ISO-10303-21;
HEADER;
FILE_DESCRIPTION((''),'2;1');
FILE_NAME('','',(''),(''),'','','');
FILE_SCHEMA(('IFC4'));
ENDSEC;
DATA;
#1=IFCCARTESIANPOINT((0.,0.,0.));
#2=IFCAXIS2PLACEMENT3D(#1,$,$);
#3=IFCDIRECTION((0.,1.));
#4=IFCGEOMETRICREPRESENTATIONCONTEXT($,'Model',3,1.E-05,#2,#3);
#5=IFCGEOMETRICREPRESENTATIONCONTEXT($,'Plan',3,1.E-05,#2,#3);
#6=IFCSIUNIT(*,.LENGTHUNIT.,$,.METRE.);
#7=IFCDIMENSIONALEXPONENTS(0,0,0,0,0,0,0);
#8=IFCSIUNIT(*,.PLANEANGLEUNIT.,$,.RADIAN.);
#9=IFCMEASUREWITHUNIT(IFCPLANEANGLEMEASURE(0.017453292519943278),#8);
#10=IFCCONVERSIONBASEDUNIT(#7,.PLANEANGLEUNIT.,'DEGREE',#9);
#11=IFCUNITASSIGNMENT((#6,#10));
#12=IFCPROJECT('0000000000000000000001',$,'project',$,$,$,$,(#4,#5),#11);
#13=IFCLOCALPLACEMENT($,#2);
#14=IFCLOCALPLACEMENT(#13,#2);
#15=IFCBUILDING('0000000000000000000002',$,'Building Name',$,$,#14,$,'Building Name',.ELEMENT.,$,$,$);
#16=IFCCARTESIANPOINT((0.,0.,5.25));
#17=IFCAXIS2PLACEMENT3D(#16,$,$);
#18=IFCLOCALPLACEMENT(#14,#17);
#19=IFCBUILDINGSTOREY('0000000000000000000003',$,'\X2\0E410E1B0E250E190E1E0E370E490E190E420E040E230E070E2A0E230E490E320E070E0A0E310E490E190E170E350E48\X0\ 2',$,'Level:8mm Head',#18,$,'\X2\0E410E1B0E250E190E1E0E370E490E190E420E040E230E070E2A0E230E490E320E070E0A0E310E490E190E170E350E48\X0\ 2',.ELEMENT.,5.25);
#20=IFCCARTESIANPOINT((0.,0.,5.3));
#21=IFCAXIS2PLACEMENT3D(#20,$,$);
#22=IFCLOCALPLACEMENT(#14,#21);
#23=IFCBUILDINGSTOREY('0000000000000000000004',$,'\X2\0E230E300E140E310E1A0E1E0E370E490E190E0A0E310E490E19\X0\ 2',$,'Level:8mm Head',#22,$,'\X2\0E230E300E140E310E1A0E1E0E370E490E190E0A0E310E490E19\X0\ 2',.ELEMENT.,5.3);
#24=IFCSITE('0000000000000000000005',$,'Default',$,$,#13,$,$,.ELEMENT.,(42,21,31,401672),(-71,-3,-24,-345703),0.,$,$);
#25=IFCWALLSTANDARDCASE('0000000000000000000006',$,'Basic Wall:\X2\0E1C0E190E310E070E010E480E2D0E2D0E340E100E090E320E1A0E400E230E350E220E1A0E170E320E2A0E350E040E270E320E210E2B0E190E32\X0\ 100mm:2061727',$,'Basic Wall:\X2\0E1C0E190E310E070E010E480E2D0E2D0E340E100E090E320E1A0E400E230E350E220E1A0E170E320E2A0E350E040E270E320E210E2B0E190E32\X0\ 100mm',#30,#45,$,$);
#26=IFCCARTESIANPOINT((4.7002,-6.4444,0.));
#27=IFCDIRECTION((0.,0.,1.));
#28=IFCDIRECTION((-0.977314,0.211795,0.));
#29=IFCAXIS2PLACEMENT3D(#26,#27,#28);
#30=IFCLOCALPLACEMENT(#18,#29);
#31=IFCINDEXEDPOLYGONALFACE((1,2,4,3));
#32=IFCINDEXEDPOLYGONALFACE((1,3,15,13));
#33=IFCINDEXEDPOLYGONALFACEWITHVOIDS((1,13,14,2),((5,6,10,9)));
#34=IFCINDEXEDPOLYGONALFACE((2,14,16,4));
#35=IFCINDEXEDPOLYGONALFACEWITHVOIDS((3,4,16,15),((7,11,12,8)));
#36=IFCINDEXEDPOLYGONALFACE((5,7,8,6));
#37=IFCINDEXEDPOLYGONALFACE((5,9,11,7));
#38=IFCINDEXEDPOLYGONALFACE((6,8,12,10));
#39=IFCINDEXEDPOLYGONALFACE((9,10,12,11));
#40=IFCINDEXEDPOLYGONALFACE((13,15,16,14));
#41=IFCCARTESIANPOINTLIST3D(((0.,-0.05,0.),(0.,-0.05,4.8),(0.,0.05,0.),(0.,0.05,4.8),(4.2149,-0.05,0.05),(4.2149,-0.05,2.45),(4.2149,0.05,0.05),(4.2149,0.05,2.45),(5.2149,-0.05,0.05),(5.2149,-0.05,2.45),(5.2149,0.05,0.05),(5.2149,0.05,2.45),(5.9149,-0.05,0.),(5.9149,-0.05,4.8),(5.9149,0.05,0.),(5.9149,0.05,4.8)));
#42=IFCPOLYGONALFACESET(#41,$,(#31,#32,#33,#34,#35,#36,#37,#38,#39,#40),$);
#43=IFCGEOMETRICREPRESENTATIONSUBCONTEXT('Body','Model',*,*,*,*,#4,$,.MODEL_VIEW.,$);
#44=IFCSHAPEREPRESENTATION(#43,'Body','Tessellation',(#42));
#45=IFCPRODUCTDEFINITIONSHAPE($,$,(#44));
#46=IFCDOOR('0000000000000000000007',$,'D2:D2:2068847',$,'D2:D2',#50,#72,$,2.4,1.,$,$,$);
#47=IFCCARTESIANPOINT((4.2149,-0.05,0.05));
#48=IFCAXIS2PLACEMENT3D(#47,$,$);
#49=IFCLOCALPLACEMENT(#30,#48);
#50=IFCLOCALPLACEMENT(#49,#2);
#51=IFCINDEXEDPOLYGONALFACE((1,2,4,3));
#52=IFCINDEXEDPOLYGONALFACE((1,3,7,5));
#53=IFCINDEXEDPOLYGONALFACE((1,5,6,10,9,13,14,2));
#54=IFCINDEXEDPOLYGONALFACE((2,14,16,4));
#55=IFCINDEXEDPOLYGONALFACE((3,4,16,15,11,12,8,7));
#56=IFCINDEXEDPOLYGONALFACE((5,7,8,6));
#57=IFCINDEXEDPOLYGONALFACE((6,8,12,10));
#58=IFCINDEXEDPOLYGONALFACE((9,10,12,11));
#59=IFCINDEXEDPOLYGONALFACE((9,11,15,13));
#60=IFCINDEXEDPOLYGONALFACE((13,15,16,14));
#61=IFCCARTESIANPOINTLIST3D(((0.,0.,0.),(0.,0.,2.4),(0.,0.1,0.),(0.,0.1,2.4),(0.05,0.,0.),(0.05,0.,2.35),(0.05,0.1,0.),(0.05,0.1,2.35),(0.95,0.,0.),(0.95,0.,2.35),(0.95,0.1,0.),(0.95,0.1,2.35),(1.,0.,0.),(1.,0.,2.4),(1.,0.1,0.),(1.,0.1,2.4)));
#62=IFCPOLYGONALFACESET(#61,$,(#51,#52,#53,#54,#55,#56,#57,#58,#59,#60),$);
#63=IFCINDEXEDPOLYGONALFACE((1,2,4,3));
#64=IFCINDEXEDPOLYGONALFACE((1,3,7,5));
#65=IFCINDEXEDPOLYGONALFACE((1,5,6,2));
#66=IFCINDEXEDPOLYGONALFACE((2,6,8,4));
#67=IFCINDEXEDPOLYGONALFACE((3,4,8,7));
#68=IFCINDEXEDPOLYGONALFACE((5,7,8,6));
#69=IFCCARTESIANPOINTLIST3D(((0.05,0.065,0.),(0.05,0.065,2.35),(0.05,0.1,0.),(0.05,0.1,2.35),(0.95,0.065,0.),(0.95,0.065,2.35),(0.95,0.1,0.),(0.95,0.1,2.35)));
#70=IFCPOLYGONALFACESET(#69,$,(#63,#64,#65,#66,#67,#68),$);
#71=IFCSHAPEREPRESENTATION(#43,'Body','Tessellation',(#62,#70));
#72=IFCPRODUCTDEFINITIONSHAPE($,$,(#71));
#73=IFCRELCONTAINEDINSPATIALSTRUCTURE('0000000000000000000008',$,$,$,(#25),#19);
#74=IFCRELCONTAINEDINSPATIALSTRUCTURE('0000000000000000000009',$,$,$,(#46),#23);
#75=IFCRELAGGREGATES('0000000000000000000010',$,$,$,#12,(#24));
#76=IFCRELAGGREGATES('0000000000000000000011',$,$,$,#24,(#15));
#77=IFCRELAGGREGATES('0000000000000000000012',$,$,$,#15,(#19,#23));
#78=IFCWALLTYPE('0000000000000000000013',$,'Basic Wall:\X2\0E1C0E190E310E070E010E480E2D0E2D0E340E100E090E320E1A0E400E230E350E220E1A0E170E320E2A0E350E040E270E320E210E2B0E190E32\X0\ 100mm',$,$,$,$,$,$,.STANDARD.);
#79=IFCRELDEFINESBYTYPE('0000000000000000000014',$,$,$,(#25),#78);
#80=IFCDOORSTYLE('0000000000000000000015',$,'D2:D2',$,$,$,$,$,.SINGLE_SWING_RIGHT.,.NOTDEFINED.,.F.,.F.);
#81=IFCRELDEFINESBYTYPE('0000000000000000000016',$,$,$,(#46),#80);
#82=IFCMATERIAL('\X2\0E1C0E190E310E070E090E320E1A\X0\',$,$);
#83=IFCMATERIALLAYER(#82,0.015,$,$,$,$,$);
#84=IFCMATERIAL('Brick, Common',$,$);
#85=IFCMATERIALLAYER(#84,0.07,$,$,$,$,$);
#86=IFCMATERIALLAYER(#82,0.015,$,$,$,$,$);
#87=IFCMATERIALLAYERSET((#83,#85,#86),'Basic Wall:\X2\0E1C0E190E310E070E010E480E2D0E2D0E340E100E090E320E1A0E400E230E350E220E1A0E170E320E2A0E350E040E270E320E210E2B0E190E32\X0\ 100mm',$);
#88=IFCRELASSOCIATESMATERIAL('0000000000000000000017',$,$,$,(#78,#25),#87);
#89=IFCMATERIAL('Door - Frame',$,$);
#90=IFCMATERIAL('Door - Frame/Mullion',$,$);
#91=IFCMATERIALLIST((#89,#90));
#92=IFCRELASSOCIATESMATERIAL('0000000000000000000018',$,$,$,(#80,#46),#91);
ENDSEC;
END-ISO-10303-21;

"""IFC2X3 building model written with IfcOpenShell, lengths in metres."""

from ifc_helpers import new_model, entity, si_unit, converted_unit, direction, frame, frame_2d, origin, origin_2d_with_axis, place, context, subcontext, project, spatial, polyline, rectangle, outline, extrude, source, transform, mapped, material, material_list, layer, layer_set, layer_usage, type_object, type_shapes, element, fill, save


model = new_model("IFC2X3")

# Units and contexts
model_context = context("Model", 3, precision=1e-05, world=origin(), true_north=direction((0.0, 1.0)))
plan_context = context("Plan", 3, precision=1e-05, world=origin(), true_north=direction((0.0, 1.0)))
body_context = subcontext(model_context, "Body", "Model", "MODEL_VIEW")
ifc_project = project(units=[si_unit("LENGTHUNIT", "METRE"), converted_unit("PLANEANGLEUNIT", "DEGREE", entity("IfcPlaneAngleMeasure", 0.017453292519943278), si_unit("PLANEANGLEUNIT", "RADIAN"), dimensions=[0, 0, 0, 0, 0, 0, 0])], contexts=[model_context, plan_context])

# Site, building, storey
site_placement = place(None, origin())
site = spatial("IfcSite", under=ifc_project, at=site_placement, Name="Default", CompositionType="ELEMENT", RefLatitude=(42, 21, 31, 401672), RefLongitude=(-71, -3, -24, -345703), RefElevation=0.0)
building_placement = place(site_placement, origin())
building = spatial("IfcBuilding", under=site, at=building_placement, Name="Building Name", LongName="Building Name", CompositionType="ELEMENT")
storey_1_placement = place(building_placement, frame((0.0, 0.0, 5.25)))
storey_1 = spatial("IfcBuildingStorey", under=building, at=storey_1_placement, Name="แปลนพื้นโครงสร้างชั้นที่ 2", ObjectType="Level:8mm Head", LongName="แปลนพื้นโครงสร้างชั้นที่ 2", CompositionType="ELEMENT", Elevation=5.25)

# Wall, openings
ifc_material_1 = material(Name="ผนังฉาบ")
ifc_layer_1 = layer(ifc_material_1, 0.015)
ifc_material_2 = material(Name="Brick, Common")
ifc_layer_2 = layer(ifc_material_2, 0.07)
ifc_layer_3 = layer(ifc_material_1, 0.015)
ifc_layer_set = layer_set([ifc_layer_1, ifc_layer_2, ifc_layer_3], Name="Basic Wall:ผนังก่ออิฐฉาบเรียบทาสีความหนา 100mm")
ifc_layer_usage_1 = layer_usage(ifc_layer_set, "AXIS2", "POSITIVE", -0.05)
wall_type = type_object("IfcWallType", Name="Basic Wall:ผนังก่ออิฐฉาบเรียบทาสีความหนา 100mm", PredefinedType="STANDARD", material=ifc_layer_set)
wall_1_placement = place(storey_1_placement, frame((4.7002, -6.4444, 0.0), z_axis=(0.0, 0.0, 1.0), x_axis=(-0.977314, 0.211795, 0.0)))
wall_1 = element("IfcWallStandardCase", 1, at=wall_1_placement, inside=storey_1, type_object=wall_type, material=ifc_layer_usage_1, Name="Basic Wall:ผนังก่ออิฐฉาบเรียบทาสีความหนา 100mm:2061727", ObjectType="Basic Wall:ผนังก่ออิฐฉาบเรียบทาสีความหนา 100mm", context=body_context, shape_type="SweptSolid", body=[
    extrude(rectangle(XDim=5.9149, YDim=0.1, at=frame_2d((2.9575, 0.0), x_axis=(-1.0, 0.0))), origin(), (0.0, 0.0, 1.0), 4.8),
])
opening_1_placement = place(wall_1_placement, frame((5.9585, -5.3027, 0.05), z_axis=(0.0, 0.0, 1.0), x_axis=(-0.977314, -0.211795, 0.0)))
element("IfcOpeningElement", 2, at=opening_1_placement, cuts=wall_1, ObjectType="Opening", context=body_context, shape_type="SweptSolid", body=[
    extrude(rectangle(XDim=2.4, YDim=1.0, at=origin_2d_with_axis()), frame((0.4256, -3.9075, 1.2), z_axis=(-0.211795, -0.977314, 0.0), x_axis=(0.0, 0.0, 1.0)), (0.0, 0.0, 1.0), 3.048),
])
opening_2_placement = place(wall_1_placement, frame((4.2149, -0.05, 0.05)))
opening_2 = element("IfcOpeningElement", 3, at=opening_2_placement, cuts=wall_1, ObjectType="Opening", context=body_context, shape_type="SweptSolid", body=[
    extrude(rectangle(XDim=2.4, YDim=1.0, at=frame_2d((1.2, 0.5), x_axis=(1.0, 0.0))), frame((0.0, 0.0, 0.0), z_axis=(0.0, 1.0, 0.0), x_axis=(0.0, 0.0, 1.0)), (0.0, 0.0, 1.0), 0.1),
])

# Shared definitions
storey_2_placement = place(building_placement, frame((0.0, 0.0, 5.3)))
storey_2 = spatial("IfcBuildingStorey", under=building, at=storey_2_placement, Name="ระดับพื้นชั้น 2", ObjectType="Level:8mm Head", LongName="ระดับพื้นชั้น 2", CompositionType="ELEMENT", Elevation=5.3)

# Door
ifc_material_3 = material(Name="Door - Frame")
ifc_material_4 = material(Name="Door - Frame/Mullion")
ifc_material_list = material_list([ifc_material_3, ifc_material_4])
door_style = type_object("IfcDoorStyle", Name="D2:D2", ConstructionType="NOTDEFINED", OperationType="SINGLE_SWING_RIGHT", ParameterTakesPrecedence=False, Sizeable=False, material=ifc_material_list)
shared_shape_1 = source(origin(), body_context, "Body", "SweptSolid", [
    extrude(outline(polyline([(-0.5, -1.1875), (-0.45, -1.1875), (-0.45, 1.1625), (0.45, 1.1625), (0.45, -1.1875), (0.5, -1.1875), (0.5, 1.2125), (-0.5, 1.2125), (-0.5, -1.1875)])), frame((0.5, 0.1, 1.1875), z_axis=(0.0, -1.0, 0.0), x_axis=(1.0, 0.0, 0.0)), (0.0, 0.0, 1.0), 0.1),
    extrude(rectangle(XDim=0.035, YDim=0.9, at=origin_2d_with_axis()), frame((0.5, 0.0825, 0.0), z_axis=(0.0, 0.0, 1.0), x_axis=(0.0, -1.0, 0.0)), (0.0, 0.0, 1.0), 2.35),
])
type_shapes(door_style, [shared_shape_1])
door_placement = place(opening_2_placement, origin())
door = element("IfcDoor", 4, at=door_placement, inside=storey_2, type_object=door_style, material=ifc_material_list, Name="D2:D2:2068847", ObjectType="D2:D2", OverallHeight=2.4, OverallWidth=1.0, context=body_context, shape_type="MappedRepresentation", body=[
    mapped(shared_shape_1, transform((0.0, 0.0, 0.0), scale=1.0)),
])
fill(opening_2, door)

save(model, "model.ifc")
